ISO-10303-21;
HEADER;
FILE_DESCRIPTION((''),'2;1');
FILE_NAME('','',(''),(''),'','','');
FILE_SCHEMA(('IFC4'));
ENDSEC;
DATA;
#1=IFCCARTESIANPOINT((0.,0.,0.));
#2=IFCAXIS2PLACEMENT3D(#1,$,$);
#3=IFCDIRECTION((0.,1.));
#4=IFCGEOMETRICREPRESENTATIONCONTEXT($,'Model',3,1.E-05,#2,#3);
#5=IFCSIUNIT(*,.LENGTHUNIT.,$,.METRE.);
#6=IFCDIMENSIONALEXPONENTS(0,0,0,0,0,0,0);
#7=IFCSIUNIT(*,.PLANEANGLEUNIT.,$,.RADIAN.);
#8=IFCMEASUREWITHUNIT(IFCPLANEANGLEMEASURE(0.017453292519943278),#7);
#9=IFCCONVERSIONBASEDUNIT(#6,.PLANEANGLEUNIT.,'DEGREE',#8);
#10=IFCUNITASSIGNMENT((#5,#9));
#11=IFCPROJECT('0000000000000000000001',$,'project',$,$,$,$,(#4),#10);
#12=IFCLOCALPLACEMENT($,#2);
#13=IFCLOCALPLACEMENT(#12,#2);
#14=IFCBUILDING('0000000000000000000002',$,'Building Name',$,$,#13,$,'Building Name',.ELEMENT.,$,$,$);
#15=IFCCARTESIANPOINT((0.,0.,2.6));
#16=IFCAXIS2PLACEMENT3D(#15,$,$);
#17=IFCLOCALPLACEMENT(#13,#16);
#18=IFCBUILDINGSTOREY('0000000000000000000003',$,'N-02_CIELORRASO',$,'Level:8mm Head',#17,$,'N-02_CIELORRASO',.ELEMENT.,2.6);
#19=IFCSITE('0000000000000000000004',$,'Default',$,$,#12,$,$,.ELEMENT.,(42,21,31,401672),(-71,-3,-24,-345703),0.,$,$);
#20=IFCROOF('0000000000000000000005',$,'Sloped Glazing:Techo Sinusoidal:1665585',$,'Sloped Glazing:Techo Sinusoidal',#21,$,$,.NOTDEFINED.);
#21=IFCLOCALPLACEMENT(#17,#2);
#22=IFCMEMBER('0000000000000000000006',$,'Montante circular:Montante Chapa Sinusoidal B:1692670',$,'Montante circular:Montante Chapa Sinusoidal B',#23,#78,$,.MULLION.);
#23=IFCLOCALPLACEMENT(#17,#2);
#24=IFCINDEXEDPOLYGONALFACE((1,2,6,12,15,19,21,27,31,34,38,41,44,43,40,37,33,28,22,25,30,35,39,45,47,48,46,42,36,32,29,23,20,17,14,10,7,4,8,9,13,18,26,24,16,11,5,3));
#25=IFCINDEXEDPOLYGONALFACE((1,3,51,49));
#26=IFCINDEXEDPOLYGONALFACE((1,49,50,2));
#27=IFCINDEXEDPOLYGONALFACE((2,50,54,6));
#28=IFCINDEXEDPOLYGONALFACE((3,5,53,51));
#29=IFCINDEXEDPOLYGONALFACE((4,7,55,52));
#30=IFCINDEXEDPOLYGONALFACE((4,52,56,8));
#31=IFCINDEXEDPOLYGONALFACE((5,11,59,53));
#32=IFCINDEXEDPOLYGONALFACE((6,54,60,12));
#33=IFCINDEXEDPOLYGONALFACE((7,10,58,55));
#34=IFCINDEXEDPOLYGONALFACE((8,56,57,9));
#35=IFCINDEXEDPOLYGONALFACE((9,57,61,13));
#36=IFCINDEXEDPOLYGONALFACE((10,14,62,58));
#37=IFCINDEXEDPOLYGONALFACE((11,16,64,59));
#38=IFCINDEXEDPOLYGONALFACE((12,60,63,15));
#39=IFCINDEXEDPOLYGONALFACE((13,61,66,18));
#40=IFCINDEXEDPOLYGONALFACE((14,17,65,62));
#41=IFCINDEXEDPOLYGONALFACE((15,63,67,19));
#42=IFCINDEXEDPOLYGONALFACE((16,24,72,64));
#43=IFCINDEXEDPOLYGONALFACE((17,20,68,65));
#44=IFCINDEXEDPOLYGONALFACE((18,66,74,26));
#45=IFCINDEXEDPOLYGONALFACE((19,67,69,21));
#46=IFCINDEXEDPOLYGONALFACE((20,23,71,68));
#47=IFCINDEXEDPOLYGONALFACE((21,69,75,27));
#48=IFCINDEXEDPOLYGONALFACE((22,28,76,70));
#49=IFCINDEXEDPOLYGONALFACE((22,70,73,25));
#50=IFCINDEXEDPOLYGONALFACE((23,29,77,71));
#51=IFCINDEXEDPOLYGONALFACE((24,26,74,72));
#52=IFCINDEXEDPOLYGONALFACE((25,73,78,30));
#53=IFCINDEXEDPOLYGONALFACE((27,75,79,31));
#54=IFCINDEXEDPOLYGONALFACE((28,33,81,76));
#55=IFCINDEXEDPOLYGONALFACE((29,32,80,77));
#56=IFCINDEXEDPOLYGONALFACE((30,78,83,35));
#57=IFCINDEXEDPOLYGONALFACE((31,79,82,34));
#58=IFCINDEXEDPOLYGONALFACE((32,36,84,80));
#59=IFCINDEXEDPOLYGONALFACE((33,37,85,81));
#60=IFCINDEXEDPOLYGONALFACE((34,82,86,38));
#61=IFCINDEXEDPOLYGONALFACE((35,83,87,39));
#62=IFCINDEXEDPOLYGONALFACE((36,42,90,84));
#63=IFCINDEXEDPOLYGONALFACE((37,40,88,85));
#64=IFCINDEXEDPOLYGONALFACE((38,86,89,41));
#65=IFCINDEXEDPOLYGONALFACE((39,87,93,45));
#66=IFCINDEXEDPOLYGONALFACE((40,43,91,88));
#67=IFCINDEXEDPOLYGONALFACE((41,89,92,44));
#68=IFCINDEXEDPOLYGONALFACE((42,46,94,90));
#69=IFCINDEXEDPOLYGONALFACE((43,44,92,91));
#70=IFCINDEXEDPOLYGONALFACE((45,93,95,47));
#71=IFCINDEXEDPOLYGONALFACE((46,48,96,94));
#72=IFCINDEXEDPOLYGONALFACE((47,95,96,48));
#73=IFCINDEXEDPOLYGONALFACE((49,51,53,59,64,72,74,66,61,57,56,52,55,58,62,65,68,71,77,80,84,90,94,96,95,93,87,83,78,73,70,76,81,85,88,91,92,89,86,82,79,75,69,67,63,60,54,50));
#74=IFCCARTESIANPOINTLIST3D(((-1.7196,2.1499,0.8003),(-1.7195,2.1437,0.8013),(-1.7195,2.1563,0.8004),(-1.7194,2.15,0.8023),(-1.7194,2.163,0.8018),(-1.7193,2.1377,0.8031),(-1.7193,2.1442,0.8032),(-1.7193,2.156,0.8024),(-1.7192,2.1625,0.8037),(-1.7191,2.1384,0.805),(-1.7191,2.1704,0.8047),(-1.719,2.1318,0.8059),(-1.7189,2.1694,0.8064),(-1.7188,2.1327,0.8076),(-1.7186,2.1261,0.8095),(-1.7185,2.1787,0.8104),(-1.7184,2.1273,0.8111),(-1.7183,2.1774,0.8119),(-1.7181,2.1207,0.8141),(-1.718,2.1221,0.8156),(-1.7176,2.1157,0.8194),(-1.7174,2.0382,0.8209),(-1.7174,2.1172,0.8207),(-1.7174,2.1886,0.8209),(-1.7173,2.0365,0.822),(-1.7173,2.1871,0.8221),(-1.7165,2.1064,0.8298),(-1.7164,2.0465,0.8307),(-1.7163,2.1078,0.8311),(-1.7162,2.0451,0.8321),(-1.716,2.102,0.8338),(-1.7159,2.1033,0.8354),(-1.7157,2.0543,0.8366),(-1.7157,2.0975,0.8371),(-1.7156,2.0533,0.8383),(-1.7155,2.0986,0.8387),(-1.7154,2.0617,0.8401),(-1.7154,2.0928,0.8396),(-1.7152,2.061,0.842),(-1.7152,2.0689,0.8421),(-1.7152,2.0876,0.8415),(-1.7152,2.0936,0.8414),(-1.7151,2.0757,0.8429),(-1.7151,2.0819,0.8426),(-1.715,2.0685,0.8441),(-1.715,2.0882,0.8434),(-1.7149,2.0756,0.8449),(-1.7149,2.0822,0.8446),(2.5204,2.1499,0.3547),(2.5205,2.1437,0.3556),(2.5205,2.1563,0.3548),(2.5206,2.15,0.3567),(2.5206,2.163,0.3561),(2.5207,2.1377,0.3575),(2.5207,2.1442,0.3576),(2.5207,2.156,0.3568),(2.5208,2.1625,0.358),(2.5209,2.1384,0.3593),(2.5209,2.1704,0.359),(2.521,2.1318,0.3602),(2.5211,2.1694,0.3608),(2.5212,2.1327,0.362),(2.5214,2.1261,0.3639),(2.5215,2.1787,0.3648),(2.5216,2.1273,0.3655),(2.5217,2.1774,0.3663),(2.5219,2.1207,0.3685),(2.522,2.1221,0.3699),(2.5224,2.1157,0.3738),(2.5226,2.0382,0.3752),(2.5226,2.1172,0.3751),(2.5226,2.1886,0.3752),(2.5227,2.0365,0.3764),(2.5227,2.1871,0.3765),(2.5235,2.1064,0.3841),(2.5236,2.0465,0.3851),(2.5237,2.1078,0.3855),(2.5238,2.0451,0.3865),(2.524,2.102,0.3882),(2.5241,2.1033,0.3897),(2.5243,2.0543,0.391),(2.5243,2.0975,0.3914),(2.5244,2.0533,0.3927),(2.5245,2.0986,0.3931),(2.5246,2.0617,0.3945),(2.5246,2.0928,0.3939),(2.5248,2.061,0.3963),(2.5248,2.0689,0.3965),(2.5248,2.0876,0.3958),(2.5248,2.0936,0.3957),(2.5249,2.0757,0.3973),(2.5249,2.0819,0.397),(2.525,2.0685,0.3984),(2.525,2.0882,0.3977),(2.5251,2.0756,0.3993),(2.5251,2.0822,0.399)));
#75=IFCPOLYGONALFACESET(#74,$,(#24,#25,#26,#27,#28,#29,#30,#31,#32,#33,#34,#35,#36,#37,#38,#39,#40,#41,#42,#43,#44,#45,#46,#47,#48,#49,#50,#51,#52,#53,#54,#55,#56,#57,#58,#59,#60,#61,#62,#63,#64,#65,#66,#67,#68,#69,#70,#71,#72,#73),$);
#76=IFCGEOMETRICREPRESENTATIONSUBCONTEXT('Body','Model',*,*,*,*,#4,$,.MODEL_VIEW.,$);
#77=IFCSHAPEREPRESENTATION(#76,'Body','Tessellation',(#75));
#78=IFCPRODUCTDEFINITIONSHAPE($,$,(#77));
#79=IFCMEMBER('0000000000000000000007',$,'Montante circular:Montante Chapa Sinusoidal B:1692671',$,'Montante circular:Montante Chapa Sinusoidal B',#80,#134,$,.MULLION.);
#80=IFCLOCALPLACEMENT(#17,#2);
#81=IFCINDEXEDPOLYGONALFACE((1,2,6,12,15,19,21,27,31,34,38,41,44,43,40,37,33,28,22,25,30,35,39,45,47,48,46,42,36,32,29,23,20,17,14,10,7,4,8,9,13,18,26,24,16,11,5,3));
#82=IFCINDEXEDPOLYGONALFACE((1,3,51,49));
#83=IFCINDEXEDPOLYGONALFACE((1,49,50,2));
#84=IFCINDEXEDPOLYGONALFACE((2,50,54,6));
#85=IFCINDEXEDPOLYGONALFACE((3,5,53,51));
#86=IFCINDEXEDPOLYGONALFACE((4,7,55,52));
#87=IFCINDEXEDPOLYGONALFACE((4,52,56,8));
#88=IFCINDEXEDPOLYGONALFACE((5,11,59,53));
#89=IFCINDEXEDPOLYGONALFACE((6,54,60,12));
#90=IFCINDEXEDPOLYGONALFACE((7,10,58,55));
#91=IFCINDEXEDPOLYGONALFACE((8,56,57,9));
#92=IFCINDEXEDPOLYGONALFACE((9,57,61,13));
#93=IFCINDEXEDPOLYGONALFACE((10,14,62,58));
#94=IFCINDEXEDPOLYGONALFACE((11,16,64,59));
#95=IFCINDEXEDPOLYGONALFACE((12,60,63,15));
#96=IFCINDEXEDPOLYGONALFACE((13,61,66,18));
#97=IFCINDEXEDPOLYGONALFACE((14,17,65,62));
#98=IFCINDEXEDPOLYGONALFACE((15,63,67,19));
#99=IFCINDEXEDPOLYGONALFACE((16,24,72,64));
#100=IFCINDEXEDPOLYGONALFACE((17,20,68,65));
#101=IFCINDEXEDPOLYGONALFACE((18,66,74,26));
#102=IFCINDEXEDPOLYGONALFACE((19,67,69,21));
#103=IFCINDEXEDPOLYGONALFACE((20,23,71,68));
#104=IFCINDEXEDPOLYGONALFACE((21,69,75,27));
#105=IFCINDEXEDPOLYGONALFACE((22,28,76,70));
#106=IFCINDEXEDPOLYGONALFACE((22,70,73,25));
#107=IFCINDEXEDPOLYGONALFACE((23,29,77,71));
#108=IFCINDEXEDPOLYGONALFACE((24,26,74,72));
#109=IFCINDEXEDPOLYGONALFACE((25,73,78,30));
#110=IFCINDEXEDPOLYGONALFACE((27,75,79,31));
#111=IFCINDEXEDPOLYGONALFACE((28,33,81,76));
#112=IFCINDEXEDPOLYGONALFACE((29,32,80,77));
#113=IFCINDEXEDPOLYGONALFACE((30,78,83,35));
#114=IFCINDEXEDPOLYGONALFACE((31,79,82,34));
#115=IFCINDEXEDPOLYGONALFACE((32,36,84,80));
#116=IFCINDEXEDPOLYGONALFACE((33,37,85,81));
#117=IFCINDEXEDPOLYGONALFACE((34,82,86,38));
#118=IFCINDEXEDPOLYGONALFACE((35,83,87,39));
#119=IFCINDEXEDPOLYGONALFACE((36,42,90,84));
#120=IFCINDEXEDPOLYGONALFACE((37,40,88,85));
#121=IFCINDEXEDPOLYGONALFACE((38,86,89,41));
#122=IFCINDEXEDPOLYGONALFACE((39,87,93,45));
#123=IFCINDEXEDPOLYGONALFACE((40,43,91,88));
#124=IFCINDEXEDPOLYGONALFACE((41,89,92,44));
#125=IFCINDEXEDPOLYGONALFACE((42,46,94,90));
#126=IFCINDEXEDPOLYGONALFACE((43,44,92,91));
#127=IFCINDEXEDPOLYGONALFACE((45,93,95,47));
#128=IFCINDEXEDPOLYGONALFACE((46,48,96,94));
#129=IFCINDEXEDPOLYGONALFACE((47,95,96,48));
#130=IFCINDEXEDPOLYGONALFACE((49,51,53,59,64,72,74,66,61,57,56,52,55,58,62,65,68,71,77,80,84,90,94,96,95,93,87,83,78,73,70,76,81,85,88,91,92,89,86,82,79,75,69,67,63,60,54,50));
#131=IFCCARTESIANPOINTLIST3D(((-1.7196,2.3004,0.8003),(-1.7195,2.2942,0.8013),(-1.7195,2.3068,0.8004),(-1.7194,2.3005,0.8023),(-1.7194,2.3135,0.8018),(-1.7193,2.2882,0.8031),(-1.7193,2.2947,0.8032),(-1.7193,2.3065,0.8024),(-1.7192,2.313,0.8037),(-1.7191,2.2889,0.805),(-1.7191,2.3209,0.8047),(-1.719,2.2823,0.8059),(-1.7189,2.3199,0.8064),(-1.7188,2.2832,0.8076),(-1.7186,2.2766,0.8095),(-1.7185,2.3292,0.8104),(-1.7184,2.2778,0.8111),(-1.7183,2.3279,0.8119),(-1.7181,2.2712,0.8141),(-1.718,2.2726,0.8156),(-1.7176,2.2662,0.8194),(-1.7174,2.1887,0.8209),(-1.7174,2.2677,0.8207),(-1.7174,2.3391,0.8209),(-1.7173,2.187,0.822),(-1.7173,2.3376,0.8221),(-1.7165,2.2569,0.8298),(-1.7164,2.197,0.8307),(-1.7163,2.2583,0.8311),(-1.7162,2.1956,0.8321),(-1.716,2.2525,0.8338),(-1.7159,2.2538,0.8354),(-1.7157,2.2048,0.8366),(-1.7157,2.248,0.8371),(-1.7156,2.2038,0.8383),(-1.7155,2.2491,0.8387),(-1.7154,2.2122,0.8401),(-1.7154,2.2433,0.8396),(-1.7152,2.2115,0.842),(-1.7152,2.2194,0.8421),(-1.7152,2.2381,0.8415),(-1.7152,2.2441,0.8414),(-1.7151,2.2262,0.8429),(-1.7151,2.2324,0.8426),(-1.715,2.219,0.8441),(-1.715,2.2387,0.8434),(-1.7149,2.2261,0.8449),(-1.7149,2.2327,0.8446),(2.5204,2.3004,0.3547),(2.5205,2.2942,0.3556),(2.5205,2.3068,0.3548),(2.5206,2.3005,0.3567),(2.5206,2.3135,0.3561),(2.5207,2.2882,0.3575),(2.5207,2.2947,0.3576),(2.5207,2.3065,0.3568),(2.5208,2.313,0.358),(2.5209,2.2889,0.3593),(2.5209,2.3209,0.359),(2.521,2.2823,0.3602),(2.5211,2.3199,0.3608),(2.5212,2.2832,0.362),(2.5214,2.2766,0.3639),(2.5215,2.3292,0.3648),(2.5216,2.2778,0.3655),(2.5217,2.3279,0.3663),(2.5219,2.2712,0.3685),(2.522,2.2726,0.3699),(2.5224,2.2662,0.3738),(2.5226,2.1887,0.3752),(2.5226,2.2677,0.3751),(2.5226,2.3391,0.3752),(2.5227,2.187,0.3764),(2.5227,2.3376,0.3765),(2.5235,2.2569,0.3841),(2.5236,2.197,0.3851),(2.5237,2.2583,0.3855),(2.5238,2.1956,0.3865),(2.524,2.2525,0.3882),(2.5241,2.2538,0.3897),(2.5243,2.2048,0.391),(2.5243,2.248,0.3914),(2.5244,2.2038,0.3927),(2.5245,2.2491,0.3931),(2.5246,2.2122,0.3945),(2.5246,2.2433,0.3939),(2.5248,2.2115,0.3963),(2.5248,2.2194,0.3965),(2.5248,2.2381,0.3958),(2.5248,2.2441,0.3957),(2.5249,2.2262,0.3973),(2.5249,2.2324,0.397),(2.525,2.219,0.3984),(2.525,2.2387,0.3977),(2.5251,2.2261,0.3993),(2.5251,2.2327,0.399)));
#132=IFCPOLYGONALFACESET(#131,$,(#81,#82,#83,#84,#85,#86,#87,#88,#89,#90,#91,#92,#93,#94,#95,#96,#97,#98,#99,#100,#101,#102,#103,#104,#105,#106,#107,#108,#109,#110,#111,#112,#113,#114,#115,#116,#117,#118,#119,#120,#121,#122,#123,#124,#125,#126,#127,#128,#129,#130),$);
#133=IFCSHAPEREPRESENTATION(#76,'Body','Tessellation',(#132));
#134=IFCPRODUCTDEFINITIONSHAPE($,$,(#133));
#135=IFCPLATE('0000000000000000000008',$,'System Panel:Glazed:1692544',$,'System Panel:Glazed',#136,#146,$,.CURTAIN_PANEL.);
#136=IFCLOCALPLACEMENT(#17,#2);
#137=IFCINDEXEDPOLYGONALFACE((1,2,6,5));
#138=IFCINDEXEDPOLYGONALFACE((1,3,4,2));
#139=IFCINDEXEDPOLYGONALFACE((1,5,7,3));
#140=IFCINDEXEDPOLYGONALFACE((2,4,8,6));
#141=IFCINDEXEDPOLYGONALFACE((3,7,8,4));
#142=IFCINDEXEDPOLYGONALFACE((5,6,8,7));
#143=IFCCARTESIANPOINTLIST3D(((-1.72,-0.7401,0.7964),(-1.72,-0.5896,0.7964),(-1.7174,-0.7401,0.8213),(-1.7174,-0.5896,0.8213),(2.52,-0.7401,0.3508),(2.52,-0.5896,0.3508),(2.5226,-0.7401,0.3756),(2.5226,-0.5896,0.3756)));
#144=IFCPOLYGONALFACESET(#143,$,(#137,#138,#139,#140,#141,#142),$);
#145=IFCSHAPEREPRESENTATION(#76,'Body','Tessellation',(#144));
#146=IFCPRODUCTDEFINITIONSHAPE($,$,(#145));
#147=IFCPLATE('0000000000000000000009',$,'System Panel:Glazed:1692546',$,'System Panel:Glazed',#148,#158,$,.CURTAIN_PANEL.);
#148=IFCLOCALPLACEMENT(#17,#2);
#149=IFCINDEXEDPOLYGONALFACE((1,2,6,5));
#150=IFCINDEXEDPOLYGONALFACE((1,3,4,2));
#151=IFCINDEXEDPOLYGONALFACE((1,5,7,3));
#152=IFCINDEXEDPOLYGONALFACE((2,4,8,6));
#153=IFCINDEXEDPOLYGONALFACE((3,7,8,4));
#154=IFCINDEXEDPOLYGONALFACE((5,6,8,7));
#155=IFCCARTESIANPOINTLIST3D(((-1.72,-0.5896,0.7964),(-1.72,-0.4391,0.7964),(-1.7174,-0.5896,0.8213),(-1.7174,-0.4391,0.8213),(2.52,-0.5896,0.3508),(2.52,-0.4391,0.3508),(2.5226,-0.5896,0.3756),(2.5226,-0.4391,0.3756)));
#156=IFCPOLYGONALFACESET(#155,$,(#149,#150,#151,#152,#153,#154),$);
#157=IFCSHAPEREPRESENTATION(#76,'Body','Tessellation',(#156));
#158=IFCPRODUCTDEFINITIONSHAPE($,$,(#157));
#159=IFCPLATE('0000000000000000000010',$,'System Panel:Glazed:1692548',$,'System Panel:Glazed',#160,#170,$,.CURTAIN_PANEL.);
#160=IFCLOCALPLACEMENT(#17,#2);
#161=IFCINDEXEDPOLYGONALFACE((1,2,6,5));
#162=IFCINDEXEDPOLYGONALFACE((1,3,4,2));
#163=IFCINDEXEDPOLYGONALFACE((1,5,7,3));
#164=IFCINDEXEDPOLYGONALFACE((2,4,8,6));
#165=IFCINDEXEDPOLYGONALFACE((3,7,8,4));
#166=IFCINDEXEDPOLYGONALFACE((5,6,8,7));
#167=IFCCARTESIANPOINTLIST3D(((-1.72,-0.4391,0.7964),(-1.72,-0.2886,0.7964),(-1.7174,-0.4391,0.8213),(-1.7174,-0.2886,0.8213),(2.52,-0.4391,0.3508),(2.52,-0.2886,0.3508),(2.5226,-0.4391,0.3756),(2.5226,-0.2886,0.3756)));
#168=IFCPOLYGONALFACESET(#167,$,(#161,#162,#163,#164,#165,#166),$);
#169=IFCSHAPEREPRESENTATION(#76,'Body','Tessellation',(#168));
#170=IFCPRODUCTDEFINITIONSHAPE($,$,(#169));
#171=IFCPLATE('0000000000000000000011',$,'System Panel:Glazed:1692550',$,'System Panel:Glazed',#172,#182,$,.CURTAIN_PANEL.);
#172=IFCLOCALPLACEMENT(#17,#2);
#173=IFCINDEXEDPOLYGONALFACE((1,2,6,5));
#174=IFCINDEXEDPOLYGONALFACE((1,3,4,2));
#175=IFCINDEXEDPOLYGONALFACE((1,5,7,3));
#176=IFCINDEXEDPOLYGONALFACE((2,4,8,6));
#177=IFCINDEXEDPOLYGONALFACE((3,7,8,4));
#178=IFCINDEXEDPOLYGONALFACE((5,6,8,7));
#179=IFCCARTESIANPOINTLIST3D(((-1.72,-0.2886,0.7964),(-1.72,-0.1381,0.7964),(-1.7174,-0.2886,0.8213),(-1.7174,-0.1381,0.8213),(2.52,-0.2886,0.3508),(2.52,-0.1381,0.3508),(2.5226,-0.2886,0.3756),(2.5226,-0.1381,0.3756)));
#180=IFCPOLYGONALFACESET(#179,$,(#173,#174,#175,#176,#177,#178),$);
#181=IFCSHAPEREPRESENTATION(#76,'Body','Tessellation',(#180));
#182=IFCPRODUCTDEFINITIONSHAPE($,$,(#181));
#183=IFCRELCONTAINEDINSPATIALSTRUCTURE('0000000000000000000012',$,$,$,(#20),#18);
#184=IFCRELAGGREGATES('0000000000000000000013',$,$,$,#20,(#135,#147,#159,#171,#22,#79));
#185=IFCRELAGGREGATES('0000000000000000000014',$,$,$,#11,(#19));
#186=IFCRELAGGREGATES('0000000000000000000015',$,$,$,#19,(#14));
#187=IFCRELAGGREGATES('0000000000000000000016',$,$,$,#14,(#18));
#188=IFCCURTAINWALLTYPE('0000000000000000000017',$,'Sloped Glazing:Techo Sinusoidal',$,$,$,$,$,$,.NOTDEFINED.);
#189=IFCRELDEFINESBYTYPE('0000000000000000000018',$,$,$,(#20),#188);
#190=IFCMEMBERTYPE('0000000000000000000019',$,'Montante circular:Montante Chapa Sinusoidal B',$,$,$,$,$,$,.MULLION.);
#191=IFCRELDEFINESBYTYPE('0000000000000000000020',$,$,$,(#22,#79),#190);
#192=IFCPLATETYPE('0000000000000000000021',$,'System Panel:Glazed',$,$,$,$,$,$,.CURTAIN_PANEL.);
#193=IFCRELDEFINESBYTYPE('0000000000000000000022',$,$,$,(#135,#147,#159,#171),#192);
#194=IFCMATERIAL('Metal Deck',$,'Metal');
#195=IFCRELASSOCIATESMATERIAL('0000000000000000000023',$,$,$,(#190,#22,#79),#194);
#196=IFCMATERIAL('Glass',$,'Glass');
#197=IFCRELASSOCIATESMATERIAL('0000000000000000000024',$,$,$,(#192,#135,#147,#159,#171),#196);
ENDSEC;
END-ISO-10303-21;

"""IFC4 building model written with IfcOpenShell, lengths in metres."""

from ifc_helpers import new_model, entity, si_unit, converted_unit, direction, frame, origin, place, context, subcontext, project, spatial, indexed_curve, outline, extrude, source, transform, mapped, material, type_object, type_shapes, element, aggregate, save


model = new_model("IFC4")

# Units and contexts
model_context = context("Model", 3, precision=1e-05, world=origin(), true_north=direction((0.0, 1.0)))
body_context = subcontext(model_context, "Body", "Model", "MODEL_VIEW")
ifc_project = project(units=[si_unit("LENGTHUNIT", "METRE"), converted_unit("PLANEANGLEUNIT", "DEGREE", entity("IfcPlaneAngleMeasure", 0.017453292519943278), si_unit("PLANEANGLEUNIT", "RADIAN"), dimensions=[0, 0, 0, 0, 0, 0, 0])], contexts=[model_context])

# Site, building, storey
site_placement = place(None, origin())
site = spatial("IfcSite", under=ifc_project, at=site_placement, Name="Default", CompositionType="ELEMENT", RefLatitude=(42, 21, 31, 401672), RefLongitude=(-71, -3, -24, -345703), RefElevation=0.0)
building_placement = place(site_placement, origin())
building = spatial("IfcBuilding", under=site, at=building_placement, Name="Building Name", LongName="Building Name", CompositionType="ELEMENT")
storey_placement = place(building_placement, frame((0.0, 0.0, 2.6)))
storey = spatial("IfcBuildingStorey", under=building, at=storey_placement, Name="N-02_CIELORRASO", ObjectType="Level:8mm Head", LongName="N-02_CIELORRASO", CompositionType="ELEMENT", Elevation=2.6)

# Roof, members, plates
curtain_wall_type = type_object("IfcCurtainWallType", Name="Sloped Glazing:Techo Sinusoidal", PredefinedType="NOTDEFINED")
roof_placement = place(storey_placement, frame((0.0, 0.0, -2.6)))
roof = element("IfcRoof", 1, at=roof_placement, inside=storey, type_object=curtain_wall_type, Name="Sloped Glazing:Techo Sinusoidal:1665585", ObjectType="Sloped Glazing:Techo Sinusoidal", PredefinedType="NOTDEFINED")
ifc_material_1 = material(Name="Metal Deck", Category="Metal")
member_type = type_object("IfcMemberType", Name="Montante circular:Montante Chapa Sinusoidal B", PredefinedType="MULLION", material=ifc_material_1)
shared_shape_1 = source(origin(), body_context, "Body", "SweptSolid", [
    extrude(outline(indexed_curve([(0.0595, -0.0443), (0.0615, -0.0443), (0.0603, -0.031), (0.0572, -0.0213), (0.053, -0.0138), (0.0481, -0.0078), (0.0427, -0.003), (0.0372, 0.0005), (0.0315, 0.0029), (0.0259, 0.0044), (0.0203, 0.0051), (0.0146, 0.005), (0.0084, 0.0041), (-0.0053, 0.0009), (-0.0123, -0.0005), (-0.0191, -0.0012), (-0.0256, -0.001), (-0.0317, 0.0001), (-0.0375, 0.0019), (-0.0428, 0.0046), (-0.0477, 0.0081), (-0.0522, 0.0128), (-0.0563, 0.0191), (-0.0597, 0.0282), (-0.0617, 0.0421), (-0.0637, 0.042), (-0.0616, 0.0277), (-0.0581, 0.0182), (-0.0537, 0.0116), (-0.049, 0.0066), (-0.0438, 0.0028), (-0.0382, 0.0001), (-0.0322, -0.0019), (-0.0258, -0.003), (-0.019, -0.0032), (-0.012, -0.0025), (-0.0048, -0.0011), (0.0088, 0.0021), (0.0147, 0.003), (0.0202, 0.0031), (0.0255, 0.0024), (0.0309, 0.001), (0.0362, -0.0013), (0.0415, -0.0046), (0.0466, -0.0092), (0.0513, -0.0149), (0.0554, -0.0221), (0.0584, -0.0314), (0.0595, -0.0443)], self_intersect=False)), frame((-0.007, 0.0228, -4.2634), z_axis=(0.0, 0.0, 1.0), x_axis=(-0.819152, -0.573576, 0.0)), (0.0, 0.0, 1.0), 4.2634),
])
type_shapes(member_type, [shared_shape_1])
member_1_placement = place(roof_placement, frame((-1.7148, 2.1194, 3.4456), z_axis=(-0.994522, 0.0, 0.104528), x_axis=(0.0, 1.0, 0.0)))
member_1 = element("IfcMember", 2, at=member_1_placement, type_object=member_type, material=ifc_material_1, Name="Montante circular:Montante Chapa Sinusoidal B:1692670", ObjectType="Montante circular:Montante Chapa Sinusoidal B", PredefinedType="MULLION", context=body_context, shape_type="MappedRepresentation", body=[
    mapped(shared_shape_1, transform((0.0, 0.0, 0.0), scale=1.0)),
])
member_2_placement = place(roof_placement, frame((-1.7148, 2.2699, 3.4456), z_axis=(-0.994522, 0.0, 0.104528), x_axis=(0.0, 1.0, 0.0)))
member_2 = element("IfcMember", 3, at=member_2_placement, type_object=member_type, material=ifc_material_1, Name="Montante circular:Montante Chapa Sinusoidal B:1692671", ObjectType="Montante circular:Montante Chapa Sinusoidal B", PredefinedType="MULLION", context=body_context, shape_type="MappedRepresentation", body=[
    mapped(shared_shape_1, transform((0.0, 0.0, 0.0), scale=1.0)),
])
ifc_material_2 = material(Name="Glass", Category="Glass")
plate_type = type_object("IfcPlateType", Name="System Panel:Glazed", PredefinedType="CURTAIN_PANEL", material=ifc_material_2)
shared_shape_2 = source(origin(), body_context, "Body", "SweptSolid", [
    extrude(outline(indexed_curve([(-0.0125, -0.0752), (0.0125, -0.0752), (0.0125, 0.0752), (-0.0125, 0.0752), (-0.0125, -0.0752)], self_intersect=False)), frame((0.0, 0.037, 0.0), z_axis=(0.0, 0.0, 1.0), x_axis=(0.0, 1.0, 0.0)), (0.0, 0.0, 1.0), 4.2634),
])
type_shapes(plate_type, [shared_shape_2])
plate_1_placement = place(roof_placement, frame((2.5252, -0.6649, 3.0), z_axis=(-0.994522, 0.0, 0.104528), x_axis=(0.0, 1.0, 0.0)))
plate_1 = element("IfcPlate", 4, at=plate_1_placement, type_object=plate_type, material=ifc_material_2, Name="System Panel:Glazed:1692544", ObjectType="System Panel:Glazed", PredefinedType="CURTAIN_PANEL", context=body_context, shape_type="MappedRepresentation", body=[
    mapped(shared_shape_2, transform((0.0, 0.0, 0.0), scale=1.0)),
])
plate_2_placement = place(roof_placement, frame((2.5252, -0.5144, 3.0), z_axis=(-0.994522, 0.0, 0.104528), x_axis=(0.0, 1.0, 0.0)))
plate_2 = element("IfcPlate", 5, at=plate_2_placement, type_object=plate_type, material=ifc_material_2, Name="System Panel:Glazed:1692546", ObjectType="System Panel:Glazed", PredefinedType="CURTAIN_PANEL", context=body_context, shape_type="MappedRepresentation", body=[
    mapped(shared_shape_2, transform((0.0, 0.0, 0.0), scale=1.0)),
])
plate_3_placement = place(roof_placement, frame((2.5252, -0.3639, 3.0), z_axis=(-0.994522, 0.0, 0.104528), x_axis=(0.0, 1.0, 0.0)))
plate_3 = element("IfcPlate", 6, at=plate_3_placement, type_object=plate_type, material=ifc_material_2, Name="System Panel:Glazed:1692548", ObjectType="System Panel:Glazed", PredefinedType="CURTAIN_PANEL", context=body_context, shape_type="MappedRepresentation", body=[
    mapped(shared_shape_2, transform((0.0, 0.0, 0.0), scale=1.0)),
])
plate_4_placement = place(roof_placement, frame((2.5252, -0.2134, 3.0), z_axis=(-0.994522, 0.0, 0.104528), x_axis=(0.0, 1.0, 0.0)))
plate_4 = element("IfcPlate", 7, at=plate_4_placement, type_object=plate_type, material=ifc_material_2, Name="System Panel:Glazed:1692550", ObjectType="System Panel:Glazed", PredefinedType="CURTAIN_PANEL", context=body_context, shape_type="MappedRepresentation", body=[
    mapped(shared_shape_2, transform((0.0, 0.0, 0.0), scale=1.0)),
])
aggregate(roof, [plate_1, plate_2, plate_3, plate_4, member_1, member_2])

save(model, "model.ifc")
